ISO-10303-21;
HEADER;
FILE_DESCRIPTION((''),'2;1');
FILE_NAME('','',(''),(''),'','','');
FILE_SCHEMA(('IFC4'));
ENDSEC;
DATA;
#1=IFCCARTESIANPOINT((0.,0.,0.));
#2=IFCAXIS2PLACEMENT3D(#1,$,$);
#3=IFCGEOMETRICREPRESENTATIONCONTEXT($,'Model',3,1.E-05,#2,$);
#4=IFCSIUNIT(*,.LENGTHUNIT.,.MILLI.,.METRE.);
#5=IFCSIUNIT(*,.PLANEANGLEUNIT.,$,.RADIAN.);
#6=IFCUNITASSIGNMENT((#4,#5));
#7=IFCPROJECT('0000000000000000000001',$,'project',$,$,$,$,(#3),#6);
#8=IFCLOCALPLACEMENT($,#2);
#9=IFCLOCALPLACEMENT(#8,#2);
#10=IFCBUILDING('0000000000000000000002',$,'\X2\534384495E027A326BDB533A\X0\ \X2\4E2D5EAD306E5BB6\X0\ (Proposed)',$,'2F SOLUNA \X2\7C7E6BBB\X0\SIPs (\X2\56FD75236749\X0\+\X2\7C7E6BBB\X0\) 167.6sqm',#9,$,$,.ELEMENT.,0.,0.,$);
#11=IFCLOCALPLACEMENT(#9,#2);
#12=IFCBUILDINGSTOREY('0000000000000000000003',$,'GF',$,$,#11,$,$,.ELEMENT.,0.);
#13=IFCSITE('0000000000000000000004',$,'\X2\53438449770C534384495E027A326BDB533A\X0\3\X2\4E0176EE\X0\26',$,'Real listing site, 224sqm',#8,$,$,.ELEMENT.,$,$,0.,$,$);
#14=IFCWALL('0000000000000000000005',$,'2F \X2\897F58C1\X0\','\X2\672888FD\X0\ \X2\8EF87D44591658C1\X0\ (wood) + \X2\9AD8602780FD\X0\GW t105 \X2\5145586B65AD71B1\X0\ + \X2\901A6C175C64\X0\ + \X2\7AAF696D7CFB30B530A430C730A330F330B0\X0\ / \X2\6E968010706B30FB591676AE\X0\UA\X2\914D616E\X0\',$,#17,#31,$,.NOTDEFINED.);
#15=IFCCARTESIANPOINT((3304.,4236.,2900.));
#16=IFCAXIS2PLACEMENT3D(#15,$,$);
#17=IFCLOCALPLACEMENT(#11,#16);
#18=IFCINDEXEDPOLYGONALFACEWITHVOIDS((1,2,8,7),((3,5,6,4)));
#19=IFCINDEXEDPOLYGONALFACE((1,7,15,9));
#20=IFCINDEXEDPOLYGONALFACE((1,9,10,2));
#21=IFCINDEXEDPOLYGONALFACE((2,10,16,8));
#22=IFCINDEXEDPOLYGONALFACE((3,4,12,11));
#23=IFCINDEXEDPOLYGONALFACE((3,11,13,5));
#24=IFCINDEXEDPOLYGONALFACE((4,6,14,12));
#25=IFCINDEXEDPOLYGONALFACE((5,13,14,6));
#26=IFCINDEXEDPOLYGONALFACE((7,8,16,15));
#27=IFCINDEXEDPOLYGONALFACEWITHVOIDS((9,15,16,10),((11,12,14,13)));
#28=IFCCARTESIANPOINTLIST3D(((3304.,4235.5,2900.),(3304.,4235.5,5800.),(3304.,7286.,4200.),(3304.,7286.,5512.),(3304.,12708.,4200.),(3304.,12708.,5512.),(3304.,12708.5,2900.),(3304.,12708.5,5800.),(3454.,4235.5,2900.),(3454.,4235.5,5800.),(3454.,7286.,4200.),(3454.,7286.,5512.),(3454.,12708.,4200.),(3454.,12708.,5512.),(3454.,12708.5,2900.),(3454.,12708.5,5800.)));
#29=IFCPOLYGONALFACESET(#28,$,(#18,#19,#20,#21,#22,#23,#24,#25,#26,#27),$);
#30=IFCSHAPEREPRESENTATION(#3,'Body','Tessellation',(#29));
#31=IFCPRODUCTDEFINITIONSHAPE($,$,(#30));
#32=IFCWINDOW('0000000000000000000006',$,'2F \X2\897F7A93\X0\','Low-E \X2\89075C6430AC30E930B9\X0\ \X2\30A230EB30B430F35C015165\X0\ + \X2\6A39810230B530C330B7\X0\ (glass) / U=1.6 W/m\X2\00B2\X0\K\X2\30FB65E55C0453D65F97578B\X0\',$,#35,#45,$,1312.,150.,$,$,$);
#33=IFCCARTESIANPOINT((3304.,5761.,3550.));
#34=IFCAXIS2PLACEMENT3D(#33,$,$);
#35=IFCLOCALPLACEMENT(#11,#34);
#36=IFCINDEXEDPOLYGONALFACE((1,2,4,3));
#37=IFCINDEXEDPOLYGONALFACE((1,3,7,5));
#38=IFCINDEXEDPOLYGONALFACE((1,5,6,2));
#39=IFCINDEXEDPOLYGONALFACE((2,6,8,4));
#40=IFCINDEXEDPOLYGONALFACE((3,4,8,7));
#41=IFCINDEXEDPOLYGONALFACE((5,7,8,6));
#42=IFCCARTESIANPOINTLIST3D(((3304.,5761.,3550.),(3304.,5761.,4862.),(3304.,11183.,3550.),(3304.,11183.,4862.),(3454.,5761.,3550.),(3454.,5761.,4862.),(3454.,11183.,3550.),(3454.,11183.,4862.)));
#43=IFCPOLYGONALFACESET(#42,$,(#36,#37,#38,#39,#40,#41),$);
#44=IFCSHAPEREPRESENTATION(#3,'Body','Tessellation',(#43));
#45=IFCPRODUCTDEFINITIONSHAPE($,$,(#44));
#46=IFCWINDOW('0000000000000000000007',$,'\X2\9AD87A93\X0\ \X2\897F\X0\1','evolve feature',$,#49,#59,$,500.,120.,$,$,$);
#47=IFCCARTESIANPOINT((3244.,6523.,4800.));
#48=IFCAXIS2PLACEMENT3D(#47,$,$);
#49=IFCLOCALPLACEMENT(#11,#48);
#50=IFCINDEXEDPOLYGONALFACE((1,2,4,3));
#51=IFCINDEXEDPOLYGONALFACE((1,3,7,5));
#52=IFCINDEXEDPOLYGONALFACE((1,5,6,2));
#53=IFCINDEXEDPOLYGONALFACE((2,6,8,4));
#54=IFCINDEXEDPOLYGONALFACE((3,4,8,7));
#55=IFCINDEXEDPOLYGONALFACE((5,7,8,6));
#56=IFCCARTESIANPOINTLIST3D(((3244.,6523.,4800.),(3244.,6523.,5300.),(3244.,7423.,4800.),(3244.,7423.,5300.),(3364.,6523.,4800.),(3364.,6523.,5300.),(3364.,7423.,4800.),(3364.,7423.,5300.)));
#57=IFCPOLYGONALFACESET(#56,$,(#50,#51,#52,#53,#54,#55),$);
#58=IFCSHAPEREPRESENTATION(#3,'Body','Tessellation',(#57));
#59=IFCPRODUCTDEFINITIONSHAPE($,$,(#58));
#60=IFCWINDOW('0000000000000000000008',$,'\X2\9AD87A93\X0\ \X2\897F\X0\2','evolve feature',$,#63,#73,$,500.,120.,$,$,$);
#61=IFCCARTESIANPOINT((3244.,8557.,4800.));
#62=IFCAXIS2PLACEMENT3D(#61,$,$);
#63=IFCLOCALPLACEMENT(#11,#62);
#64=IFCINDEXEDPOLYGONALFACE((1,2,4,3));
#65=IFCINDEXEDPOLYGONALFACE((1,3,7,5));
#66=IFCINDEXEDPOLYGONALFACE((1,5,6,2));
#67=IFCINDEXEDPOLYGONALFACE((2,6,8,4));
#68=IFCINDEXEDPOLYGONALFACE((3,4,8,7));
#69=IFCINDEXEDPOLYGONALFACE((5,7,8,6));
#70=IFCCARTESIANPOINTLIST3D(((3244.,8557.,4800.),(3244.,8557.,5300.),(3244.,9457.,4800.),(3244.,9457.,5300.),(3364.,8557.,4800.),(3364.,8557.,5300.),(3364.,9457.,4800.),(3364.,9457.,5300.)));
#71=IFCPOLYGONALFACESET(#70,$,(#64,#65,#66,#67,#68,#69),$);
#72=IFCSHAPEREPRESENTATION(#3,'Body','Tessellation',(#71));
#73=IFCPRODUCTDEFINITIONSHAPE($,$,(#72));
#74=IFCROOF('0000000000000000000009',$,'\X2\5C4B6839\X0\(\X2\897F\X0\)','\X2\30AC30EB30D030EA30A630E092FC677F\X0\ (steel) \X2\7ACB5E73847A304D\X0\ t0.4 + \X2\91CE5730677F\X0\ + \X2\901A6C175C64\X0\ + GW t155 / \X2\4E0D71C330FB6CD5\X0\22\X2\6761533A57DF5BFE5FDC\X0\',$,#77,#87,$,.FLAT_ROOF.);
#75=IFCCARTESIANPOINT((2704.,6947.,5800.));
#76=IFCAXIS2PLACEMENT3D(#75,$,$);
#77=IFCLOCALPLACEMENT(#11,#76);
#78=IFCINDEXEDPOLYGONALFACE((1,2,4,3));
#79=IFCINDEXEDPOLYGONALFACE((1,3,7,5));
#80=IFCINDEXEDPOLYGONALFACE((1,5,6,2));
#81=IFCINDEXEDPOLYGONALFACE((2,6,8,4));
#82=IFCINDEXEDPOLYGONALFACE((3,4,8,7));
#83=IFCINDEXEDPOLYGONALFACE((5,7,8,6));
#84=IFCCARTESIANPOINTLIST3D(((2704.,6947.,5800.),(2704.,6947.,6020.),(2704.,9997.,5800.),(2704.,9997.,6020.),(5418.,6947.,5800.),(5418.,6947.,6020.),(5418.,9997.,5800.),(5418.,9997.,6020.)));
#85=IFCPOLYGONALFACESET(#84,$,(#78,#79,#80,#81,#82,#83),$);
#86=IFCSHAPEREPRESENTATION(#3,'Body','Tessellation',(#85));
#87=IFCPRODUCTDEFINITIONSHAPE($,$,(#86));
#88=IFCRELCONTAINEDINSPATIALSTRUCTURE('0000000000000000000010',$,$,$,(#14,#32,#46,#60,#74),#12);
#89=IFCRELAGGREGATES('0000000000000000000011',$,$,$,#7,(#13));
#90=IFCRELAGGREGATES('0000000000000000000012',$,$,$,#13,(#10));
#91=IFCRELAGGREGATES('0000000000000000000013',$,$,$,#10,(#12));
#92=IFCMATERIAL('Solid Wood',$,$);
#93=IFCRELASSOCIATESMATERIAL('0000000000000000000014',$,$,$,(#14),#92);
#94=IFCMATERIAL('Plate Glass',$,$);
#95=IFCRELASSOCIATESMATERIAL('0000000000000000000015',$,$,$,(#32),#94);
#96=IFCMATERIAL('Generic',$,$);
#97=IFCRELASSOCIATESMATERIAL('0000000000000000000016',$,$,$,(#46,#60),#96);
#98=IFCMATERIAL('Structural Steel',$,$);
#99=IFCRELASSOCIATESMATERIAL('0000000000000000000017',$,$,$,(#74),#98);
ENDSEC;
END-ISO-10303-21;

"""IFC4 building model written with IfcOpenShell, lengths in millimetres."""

from ifc_helpers import new_model, si_unit, frame, frame_2d, origin, place, context, project, spatial, rectangle, extrude, material, element, fill, save


model = new_model("IFC4")

# Units and contexts
model_context = context("Model", 3, precision=1e-05, world=origin())
ifc_project = project(units=[si_unit("LENGTHUNIT", "METRE", prefix="MILLI"), si_unit("PLANEANGLEUNIT", "RADIAN")], contexts=[model_context])

# Site, building, storey
site_placement = place(None, origin())
site = spatial("IfcSite", under=ifc_project, at=site_placement, Name="千葉県千葉市稲毛区3丁目26", ObjectType="Real listing site, 224sqm", CompositionType="ELEMENT", RefElevation=0.0)
building_placement = place(site_placement, origin())
building = spatial("IfcBuilding", under=site, at=building_placement, Name="千葉市稲毛区 中庭の家 (Proposed)", ObjectType="2F SOLUNA 籾殻SIPs (国産杉+籾殻) 167.6sqm", CompositionType="ELEMENT", ElevationOfRefHeight=0.0, ElevationOfTerrain=0.0)
storey_placement = place(building_placement, origin())
storey = spatial("IfcBuildingStorey", under=building, at=storey_placement, Name="GF", CompositionType="ELEMENT", Elevation=0.0)

# Shared definitions
ifc_material_1 = material(Name="Solid Wood")
ifc_material_2 = material(Name="Generic")

# Shared definitions
ifc_material_3 = material(Name="Plate Glass")

# Wall, openings, windows
wall_1_placement = place(storey_placement, frame((3304.0, 4236.0, 2900.0)))
wall_1 = element("IfcWall", 1, at=wall_1_placement, inside=storey, material=ifc_material_1, Name="2F 西壁", Description="木製 軸組外壁 (wood) + 高性能GW t105 充填断熱 + 通気層 + 窯業系サイディング / 準耐火・外皮UA配慮", PredefinedType="NOTDEFINED", context=model_context, shape_type="SweptSolid", body=[
    extrude(rectangle(XDim=150.0, YDim=8473.0, at=frame_2d((75.0, 4236.0))), frame((3304.0, 4236.0, 2900.0)), (0.0, 0.0, 1.0), 2900.0),
])
opening_1_placement = place(storey_placement, frame((3304.0, 5761.0, 3550.0)))
opening_1 = element("IfcOpeningElement", 2, at=opening_1_placement, cuts=wall_1, PredefinedType="NOTDEFINED", context=model_context, shape_type="SweptSolid", body=[
    extrude(rectangle(XDim=150.0, YDim=5422.0, at=frame_2d((75.0, 2711.0))), frame((3304.0, 5761.0, 3550.0)), (0.0, 0.0, 1.0), 1312.0),
])
opening_2_placement = place(storey_placement, frame((3244.0, 6523.0, 4800.0)))
opening_2 = element("IfcOpeningElement", 3, at=opening_2_placement, cuts=wall_1, PredefinedType="NOTDEFINED", context=model_context, shape_type="SweptSolid", body=[
    extrude(rectangle(XDim=120.0, YDim=900.0, at=frame_2d((60.0, 450.0))), frame((3244.0, 6523.0, 4800.0)), (0.0, 0.0, 1.0), 500.0),
])
opening_3_placement = place(storey_placement, frame((3244.0, 8557.0, 4800.0)))
opening_3 = element("IfcOpeningElement", 4, at=opening_3_placement, cuts=wall_1, PredefinedType="NOTDEFINED", context=model_context, shape_type="SweptSolid", body=[
    extrude(rectangle(XDim=120.0, YDim=900.0, at=frame_2d((60.0, 450.0))), frame((3244.0, 8557.0, 4800.0)), (0.0, 0.0, 1.0), 500.0),
])
window_1_placement = place(storey_placement, frame((3304.0, 5761.0, 3550.0)))
window_1 = element("IfcWindow", 5, at=window_1_placement, inside=storey, material=ifc_material_3, Name="2F 西窓", Description="Low-E 複層ガラス アルゴン封入 + 樹脂サッシ (glass) / U=1.6 W/m²K・日射取得型", OverallHeight=1312.0, OverallWidth=150.0, context=model_context, shape_type="SweptSolid", body=[
    extrude(rectangle(XDim=150.0, YDim=5422.0, at=frame_2d((75.0, 2711.0))), frame((3304.0, 5761.0, 3550.0)), (0.0, 0.0, 1.0), 1312.0),
])
fill(opening_1, window_1)
window_2_placement = place(storey_placement, frame((3244.0, 6523.0, 4800.0)))
window_2 = element("IfcWindow", 6, at=window_2_placement, inside=storey, material=ifc_material_2, Name="高窓 西1", Description="evolve feature", OverallHeight=500.0, OverallWidth=120.0, context=model_context, shape_type="SweptSolid", body=[
    extrude(rectangle(XDim=120.0, YDim=900.0, at=frame_2d((60.0, 450.0))), frame((3244.0, 6523.0, 4800.0)), (0.0, 0.0, 1.0), 500.0),
])
fill(opening_2, window_2)
window_3_placement = place(storey_placement, frame((3244.0, 8557.0, 4800.0)))
window_3 = element("IfcWindow", 7, at=window_3_placement, inside=storey, material=ifc_material_2, Name="高窓 西2", Description="evolve feature", OverallHeight=500.0, OverallWidth=120.0, context=model_context, shape_type="SweptSolid", body=[
    extrude(rectangle(XDim=120.0, YDim=900.0, at=frame_2d((60.0, 450.0))), frame((3244.0, 8557.0, 4800.0)), (0.0, 0.0, 1.0), 500.0),
])
fill(opening_3, window_3)

# Roof
ifc_material_4 = material(Name="Structural Steel")
roof_1_placement = place(storey_placement, frame((2704.0, 6947.0, 5800.0)))
element("IfcRoof", 8, at=roof_1_placement, inside=storey, material=ifc_material_4, Name="屋根(西)", Description="ガルバリウム鋼板 (steel) 立平葺き t0.4 + 野地板 + 通気層 + GW t155 / 不燃・法22条区域対応", PredefinedType="FLAT_ROOF", context=model_context, shape_type="SweptSolid", body=[
    extrude(rectangle(XDim=2714.0, YDim=3050.0, at=frame_2d((1357.0, 1525.0))), frame((2704.0, 6947.0, 5800.0)), (0.0, 0.0, 1.0), 220.0),
])

save(model, "model.ifc")
